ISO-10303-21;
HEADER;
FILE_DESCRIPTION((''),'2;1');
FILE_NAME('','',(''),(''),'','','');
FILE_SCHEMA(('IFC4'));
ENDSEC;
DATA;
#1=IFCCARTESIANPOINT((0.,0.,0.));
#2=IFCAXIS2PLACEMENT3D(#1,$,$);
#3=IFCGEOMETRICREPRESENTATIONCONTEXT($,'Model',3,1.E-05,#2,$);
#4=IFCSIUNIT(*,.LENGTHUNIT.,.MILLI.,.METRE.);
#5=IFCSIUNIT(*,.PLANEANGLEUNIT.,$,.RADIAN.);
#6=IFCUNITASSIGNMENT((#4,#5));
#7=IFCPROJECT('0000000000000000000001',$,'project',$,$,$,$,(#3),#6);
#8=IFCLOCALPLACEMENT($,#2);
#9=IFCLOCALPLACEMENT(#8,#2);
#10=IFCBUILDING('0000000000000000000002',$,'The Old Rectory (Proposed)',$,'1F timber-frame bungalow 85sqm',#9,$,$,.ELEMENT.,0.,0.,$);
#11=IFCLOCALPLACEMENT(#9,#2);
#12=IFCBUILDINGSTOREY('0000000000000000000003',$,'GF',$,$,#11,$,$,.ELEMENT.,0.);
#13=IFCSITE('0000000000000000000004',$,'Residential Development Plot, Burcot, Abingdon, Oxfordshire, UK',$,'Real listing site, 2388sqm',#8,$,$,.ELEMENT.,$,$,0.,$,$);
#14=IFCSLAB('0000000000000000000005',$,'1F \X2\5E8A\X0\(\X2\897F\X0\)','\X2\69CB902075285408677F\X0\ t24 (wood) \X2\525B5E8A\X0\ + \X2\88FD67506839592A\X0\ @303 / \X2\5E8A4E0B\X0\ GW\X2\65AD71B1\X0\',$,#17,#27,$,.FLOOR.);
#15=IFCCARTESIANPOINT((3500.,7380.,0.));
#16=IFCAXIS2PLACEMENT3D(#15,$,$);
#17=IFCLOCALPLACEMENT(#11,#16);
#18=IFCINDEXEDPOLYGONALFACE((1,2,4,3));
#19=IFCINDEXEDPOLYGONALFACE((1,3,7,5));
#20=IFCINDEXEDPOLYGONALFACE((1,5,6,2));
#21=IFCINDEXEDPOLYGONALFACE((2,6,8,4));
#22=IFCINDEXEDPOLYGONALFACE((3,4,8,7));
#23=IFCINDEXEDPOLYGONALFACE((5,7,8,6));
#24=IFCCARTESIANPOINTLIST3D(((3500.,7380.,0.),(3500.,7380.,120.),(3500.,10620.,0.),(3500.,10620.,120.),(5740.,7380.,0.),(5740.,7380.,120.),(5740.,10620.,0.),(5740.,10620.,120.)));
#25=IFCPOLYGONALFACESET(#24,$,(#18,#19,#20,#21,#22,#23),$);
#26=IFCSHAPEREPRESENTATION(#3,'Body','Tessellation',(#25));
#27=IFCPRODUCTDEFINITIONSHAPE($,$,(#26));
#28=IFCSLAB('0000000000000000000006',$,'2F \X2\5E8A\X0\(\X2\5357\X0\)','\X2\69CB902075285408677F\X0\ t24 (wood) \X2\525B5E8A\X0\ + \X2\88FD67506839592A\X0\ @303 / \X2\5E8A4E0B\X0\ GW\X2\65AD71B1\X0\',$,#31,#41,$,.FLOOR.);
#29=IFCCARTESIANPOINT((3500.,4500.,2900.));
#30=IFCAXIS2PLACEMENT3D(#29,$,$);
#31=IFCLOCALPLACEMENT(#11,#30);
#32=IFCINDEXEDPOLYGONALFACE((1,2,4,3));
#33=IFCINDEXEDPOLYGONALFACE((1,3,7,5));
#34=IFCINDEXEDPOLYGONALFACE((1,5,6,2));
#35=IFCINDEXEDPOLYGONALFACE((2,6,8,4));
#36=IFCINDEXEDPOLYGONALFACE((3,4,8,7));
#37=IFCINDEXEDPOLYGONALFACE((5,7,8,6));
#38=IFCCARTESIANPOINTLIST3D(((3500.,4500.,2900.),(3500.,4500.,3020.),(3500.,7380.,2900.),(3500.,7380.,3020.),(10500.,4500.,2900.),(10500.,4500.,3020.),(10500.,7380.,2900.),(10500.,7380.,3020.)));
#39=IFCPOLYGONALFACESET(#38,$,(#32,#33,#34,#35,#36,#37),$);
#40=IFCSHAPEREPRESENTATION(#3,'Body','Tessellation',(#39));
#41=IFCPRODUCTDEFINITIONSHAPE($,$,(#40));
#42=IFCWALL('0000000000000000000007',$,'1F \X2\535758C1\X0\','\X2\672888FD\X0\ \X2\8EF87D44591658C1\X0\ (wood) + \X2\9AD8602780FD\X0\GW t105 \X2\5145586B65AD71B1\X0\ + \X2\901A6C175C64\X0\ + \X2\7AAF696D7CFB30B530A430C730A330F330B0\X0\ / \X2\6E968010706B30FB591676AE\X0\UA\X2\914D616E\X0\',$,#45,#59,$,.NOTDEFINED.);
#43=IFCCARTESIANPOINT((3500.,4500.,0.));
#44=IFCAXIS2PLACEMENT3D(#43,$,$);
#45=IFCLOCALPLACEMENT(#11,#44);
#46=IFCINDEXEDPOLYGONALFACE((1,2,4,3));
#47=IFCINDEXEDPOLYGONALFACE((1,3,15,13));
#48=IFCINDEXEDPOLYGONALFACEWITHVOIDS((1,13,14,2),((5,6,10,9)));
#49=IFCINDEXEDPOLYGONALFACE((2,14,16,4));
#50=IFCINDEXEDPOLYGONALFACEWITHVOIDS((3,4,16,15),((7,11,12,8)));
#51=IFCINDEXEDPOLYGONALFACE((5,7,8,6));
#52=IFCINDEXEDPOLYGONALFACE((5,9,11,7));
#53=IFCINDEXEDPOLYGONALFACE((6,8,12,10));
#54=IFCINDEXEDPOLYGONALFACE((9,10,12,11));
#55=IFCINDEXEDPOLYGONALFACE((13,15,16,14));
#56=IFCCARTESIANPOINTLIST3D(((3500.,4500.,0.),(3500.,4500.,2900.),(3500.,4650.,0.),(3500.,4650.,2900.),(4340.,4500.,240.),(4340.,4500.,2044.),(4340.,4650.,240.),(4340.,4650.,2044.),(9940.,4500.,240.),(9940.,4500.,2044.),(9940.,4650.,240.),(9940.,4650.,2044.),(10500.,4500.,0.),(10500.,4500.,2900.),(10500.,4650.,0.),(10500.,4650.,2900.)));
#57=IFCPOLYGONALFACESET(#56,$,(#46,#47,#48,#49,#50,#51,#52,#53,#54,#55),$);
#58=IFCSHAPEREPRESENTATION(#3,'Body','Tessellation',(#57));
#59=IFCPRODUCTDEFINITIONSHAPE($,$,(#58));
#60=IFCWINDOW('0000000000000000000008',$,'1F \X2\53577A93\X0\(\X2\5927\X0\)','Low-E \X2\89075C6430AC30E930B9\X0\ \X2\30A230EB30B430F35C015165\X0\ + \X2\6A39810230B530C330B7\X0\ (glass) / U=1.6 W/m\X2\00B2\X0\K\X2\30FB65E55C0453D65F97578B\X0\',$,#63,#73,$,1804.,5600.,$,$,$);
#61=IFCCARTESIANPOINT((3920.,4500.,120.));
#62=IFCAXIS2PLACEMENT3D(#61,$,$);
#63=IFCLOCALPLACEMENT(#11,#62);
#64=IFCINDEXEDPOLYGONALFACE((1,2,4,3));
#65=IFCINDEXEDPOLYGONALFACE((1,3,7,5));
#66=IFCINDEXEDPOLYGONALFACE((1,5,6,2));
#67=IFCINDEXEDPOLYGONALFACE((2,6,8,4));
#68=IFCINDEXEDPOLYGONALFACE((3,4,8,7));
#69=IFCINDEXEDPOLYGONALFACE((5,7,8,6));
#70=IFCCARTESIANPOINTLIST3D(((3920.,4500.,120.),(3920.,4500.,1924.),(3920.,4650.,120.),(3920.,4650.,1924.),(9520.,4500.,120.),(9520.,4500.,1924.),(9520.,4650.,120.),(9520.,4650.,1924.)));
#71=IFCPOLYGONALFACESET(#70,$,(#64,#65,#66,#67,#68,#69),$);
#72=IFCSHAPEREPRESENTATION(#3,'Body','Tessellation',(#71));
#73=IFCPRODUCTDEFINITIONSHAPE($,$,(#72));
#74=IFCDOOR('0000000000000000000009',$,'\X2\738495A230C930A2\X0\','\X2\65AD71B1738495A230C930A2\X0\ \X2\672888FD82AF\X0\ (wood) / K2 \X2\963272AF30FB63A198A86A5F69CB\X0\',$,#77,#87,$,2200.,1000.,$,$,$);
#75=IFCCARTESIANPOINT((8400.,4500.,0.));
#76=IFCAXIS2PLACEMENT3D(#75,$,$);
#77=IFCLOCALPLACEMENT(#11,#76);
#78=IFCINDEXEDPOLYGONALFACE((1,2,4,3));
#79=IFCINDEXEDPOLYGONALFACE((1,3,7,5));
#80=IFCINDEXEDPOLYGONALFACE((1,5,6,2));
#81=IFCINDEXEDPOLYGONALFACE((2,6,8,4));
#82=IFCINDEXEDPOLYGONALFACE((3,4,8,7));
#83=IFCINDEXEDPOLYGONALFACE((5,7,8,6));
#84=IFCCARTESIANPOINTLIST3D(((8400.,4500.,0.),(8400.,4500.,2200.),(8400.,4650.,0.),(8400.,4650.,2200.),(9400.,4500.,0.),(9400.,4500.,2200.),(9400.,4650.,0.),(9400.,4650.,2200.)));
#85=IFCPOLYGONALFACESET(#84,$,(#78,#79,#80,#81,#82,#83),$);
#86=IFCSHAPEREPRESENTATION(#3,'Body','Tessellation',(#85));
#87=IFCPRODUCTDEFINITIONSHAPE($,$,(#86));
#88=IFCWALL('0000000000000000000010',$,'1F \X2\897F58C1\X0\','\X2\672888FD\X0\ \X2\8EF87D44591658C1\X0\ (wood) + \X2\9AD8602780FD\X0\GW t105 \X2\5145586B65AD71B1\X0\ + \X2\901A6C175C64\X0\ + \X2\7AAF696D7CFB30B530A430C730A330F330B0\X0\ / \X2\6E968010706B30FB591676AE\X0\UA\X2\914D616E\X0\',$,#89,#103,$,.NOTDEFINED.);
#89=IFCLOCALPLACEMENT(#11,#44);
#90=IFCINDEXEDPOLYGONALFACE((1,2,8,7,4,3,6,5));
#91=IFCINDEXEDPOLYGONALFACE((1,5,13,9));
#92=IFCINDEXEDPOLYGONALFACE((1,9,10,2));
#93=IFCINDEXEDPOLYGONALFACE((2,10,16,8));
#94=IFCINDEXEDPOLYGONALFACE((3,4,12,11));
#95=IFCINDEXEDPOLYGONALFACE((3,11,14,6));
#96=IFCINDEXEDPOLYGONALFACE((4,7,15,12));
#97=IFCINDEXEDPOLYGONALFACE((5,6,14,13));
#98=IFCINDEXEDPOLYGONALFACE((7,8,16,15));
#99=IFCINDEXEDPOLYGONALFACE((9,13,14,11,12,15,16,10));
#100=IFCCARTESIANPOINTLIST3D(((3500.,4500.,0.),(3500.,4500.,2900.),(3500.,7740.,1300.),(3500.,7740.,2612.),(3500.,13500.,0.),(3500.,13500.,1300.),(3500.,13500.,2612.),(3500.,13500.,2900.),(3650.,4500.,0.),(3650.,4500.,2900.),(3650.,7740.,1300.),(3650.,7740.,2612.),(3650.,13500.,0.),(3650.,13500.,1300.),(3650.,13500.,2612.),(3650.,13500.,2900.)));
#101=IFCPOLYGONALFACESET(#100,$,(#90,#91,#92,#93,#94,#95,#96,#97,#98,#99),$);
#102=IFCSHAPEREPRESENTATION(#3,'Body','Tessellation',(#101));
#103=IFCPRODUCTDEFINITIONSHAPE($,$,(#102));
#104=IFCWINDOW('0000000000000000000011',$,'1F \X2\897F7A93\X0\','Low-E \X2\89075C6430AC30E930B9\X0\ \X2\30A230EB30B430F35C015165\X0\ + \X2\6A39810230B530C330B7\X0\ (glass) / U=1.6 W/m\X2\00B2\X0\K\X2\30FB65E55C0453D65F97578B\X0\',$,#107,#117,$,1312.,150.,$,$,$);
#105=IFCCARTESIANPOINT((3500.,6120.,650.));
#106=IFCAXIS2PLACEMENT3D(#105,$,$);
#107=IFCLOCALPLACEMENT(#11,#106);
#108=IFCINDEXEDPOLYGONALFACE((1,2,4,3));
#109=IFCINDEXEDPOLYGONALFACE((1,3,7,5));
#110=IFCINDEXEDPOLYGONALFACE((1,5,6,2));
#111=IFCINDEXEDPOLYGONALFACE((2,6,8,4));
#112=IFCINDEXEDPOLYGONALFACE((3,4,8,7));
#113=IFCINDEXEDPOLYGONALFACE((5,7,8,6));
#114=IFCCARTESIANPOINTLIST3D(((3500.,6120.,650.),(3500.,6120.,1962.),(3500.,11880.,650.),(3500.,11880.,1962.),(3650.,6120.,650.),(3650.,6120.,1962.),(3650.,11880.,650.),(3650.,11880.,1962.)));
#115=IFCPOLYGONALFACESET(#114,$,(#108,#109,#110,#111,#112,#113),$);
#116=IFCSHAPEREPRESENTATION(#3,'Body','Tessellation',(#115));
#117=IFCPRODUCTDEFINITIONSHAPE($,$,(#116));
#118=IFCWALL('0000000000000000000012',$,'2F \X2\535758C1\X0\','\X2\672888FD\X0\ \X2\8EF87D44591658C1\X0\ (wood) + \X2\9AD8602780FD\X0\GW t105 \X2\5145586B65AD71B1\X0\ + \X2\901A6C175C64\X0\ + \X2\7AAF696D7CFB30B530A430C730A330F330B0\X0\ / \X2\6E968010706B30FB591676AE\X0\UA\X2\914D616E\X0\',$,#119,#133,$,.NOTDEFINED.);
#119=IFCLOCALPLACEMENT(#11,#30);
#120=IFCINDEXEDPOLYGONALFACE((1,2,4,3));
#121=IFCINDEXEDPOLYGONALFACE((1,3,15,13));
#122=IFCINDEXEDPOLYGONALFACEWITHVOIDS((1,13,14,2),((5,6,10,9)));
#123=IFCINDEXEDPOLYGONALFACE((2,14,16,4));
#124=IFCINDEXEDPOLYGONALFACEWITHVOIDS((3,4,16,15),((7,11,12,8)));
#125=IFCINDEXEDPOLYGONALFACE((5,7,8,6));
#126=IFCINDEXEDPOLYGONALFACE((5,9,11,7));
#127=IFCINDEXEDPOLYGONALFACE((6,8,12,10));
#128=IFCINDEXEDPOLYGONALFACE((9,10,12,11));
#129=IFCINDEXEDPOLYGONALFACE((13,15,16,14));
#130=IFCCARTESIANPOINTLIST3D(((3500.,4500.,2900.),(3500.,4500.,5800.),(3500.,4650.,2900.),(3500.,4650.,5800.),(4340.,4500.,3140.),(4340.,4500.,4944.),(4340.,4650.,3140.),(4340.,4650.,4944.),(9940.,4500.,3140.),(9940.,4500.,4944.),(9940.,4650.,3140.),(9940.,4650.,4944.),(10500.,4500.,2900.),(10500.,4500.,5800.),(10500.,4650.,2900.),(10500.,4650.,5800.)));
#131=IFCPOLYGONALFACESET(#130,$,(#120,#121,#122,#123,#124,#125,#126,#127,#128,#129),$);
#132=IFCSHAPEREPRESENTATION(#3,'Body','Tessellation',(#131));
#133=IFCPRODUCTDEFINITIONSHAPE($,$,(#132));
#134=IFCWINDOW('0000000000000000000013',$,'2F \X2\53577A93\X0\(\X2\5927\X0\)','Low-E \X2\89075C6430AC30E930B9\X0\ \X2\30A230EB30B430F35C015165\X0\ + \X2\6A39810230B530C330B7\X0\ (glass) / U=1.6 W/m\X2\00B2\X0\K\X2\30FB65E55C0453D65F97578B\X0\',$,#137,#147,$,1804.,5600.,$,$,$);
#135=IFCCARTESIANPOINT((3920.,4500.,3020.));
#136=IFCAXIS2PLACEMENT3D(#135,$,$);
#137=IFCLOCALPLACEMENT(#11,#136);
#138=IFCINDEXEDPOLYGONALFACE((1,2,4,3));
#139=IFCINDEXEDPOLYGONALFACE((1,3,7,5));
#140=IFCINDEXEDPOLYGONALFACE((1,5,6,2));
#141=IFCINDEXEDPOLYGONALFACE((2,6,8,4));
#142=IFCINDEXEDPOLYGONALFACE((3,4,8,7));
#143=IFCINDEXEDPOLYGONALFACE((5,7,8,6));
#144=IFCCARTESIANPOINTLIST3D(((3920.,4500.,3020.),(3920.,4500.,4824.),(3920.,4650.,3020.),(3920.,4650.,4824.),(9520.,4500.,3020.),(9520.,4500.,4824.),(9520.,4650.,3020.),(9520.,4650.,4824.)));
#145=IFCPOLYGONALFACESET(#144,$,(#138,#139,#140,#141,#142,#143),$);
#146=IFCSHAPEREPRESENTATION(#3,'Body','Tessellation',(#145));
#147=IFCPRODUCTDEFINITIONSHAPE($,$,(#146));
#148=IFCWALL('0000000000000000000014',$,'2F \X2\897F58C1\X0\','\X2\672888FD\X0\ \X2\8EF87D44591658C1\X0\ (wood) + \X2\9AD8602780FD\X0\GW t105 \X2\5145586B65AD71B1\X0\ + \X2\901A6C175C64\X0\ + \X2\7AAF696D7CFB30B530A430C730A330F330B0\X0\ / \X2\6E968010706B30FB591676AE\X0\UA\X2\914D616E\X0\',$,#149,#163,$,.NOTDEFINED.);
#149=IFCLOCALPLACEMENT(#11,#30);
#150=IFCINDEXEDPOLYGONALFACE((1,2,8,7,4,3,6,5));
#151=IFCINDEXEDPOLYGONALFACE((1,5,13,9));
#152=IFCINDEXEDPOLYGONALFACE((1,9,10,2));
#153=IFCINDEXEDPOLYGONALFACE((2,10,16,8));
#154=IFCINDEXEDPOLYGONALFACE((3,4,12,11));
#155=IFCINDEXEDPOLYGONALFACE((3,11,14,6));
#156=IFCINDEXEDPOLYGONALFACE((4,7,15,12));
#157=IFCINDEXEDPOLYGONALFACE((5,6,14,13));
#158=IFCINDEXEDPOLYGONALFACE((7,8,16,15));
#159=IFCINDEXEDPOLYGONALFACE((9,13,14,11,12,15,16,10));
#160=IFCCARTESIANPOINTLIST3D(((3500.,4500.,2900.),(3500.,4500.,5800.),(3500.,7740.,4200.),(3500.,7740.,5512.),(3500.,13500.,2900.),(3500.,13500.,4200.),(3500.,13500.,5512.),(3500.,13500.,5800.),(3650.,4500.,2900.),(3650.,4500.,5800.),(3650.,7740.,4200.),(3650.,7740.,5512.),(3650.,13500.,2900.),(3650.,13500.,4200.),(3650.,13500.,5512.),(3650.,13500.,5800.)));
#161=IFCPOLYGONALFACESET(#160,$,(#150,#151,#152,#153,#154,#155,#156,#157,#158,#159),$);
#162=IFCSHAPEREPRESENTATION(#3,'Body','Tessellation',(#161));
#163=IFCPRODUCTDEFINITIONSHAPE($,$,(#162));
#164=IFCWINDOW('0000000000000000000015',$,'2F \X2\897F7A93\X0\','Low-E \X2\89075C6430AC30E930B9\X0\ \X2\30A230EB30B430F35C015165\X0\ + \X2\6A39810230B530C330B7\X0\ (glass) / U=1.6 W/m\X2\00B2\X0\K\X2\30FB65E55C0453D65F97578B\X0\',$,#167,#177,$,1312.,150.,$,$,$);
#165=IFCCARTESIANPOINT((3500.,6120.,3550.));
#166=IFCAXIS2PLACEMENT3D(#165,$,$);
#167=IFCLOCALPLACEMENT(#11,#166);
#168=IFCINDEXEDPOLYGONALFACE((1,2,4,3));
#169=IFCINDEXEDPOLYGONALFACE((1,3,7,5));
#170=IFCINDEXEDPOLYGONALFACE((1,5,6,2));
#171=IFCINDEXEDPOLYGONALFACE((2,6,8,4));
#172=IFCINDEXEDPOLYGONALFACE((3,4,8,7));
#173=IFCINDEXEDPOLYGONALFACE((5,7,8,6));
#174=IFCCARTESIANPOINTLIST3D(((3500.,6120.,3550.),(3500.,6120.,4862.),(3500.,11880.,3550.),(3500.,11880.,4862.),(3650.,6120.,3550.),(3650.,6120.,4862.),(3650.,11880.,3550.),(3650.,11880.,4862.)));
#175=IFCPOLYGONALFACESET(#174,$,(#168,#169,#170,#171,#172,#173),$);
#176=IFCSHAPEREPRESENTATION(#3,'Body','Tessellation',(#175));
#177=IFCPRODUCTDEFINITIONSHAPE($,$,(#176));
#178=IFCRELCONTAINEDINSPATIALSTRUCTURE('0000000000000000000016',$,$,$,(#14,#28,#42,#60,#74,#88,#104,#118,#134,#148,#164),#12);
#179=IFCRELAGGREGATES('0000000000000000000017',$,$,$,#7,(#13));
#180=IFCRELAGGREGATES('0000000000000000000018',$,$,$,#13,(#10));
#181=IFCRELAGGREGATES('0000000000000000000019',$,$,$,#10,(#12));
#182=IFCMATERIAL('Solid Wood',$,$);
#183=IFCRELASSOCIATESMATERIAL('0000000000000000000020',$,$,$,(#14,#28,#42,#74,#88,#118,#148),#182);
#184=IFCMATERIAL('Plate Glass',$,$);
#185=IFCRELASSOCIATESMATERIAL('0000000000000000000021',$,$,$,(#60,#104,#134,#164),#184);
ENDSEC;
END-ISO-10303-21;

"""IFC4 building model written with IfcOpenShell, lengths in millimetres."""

from ifc_helpers import new_model, si_unit, frame, frame_2d, origin, place, context, project, spatial, rectangle, extrude, material, element, fill, save


model = new_model("IFC4")

# Units and contexts
model_context = context("Model", 3, precision=1e-05, world=origin())
ifc_project = project(units=[si_unit("LENGTHUNIT", "METRE", prefix="MILLI"), si_unit("PLANEANGLEUNIT", "RADIAN")], contexts=[model_context])

# Site, building, storey
site_placement = place(None, origin())
site = spatial("IfcSite", under=ifc_project, at=site_placement, Name="Residential Development Plot, Burcot, Abingdon, Oxfordshire, UK", ObjectType="Real listing site, 2388sqm", CompositionType="ELEMENT", RefElevation=0.0)
building_placement = place(site_placement, origin())
building = spatial("IfcBuilding", under=site, at=building_placement, Name="The Old Rectory (Proposed)", ObjectType="1F timber-frame bungalow 85sqm", CompositionType="ELEMENT", ElevationOfRefHeight=0.0, ElevationOfTerrain=0.0)
storey_placement = place(building_placement, origin())
storey = spatial("IfcBuildingStorey", under=building, at=storey_placement, Name="GF", CompositionType="ELEMENT", Elevation=0.0)

# Slabs
ifc_material_1 = material(Name="Solid Wood")
slab_1_placement = place(storey_placement, frame((3500.0, 7380.0, 0.0)))
element("IfcSlab", 1, at=slab_1_placement, inside=storey, material=ifc_material_1, Name="1F 床(西)", Description="構造用合板 t24 (wood) 剛床 + 製材根太 @303 / 床下 GW断熱", PredefinedType="FLOOR", context=model_context, shape_type="SweptSolid", body=[
    extrude(rectangle(XDim=2240.0, YDim=3240.0, at=frame_2d((1120.0, 1620.0))), frame((3500.0, 7380.0, 0.0)), (0.0, 0.0, 1.0), 120.0),
])
slab_2_placement = place(storey_placement, frame((3500.0, 4500.0, 2900.0)))
element("IfcSlab", 2, at=slab_2_placement, inside=storey, material=ifc_material_1, Name="2F 床(南)", Description="構造用合板 t24 (wood) 剛床 + 製材根太 @303 / 床下 GW断熱", PredefinedType="FLOOR", context=model_context, shape_type="SweptSolid", body=[
    extrude(rectangle(XDim=7000.0, YDim=2880.0, at=frame_2d((3500.0, 1440.0))), frame((3500.0, 4500.0, 2900.0)), (0.0, 0.0, 1.0), 120.0),
])

# Wall, openings, window, door
wall_1_placement = place(storey_placement, frame((3500.0, 4500.0, 0.0)))
wall_1 = element("IfcWall", 3, at=wall_1_placement, inside=storey, material=ifc_material_1, Name="1F 南壁", Description="木製 軸組外壁 (wood) + 高性能GW t105 充填断熱 + 通気層 + 窯業系サイディング / 準耐火・外皮UA配慮", PredefinedType="NOTDEFINED", context=model_context, shape_type="SweptSolid", body=[
    extrude(rectangle(XDim=7000.0, YDim=150.0, at=frame_2d((3500.0, 75.0))), frame((3500.0, 4500.0, 0.0)), (0.0, 0.0, 1.0), 2900.0),
])
opening_1_placement = place(storey_placement, frame((3920.0, 4500.0, 120.0)))
opening_1 = element("IfcOpeningElement", 4, at=opening_1_placement, cuts=wall_1, PredefinedType="NOTDEFINED", context=model_context, shape_type="SweptSolid", body=[
    extrude(rectangle(XDim=5600.0, YDim=150.0, at=frame_2d((2800.0, 75.0))), frame((3920.0, 4500.0, 120.0)), (0.0, 0.0, 1.0), 1804.0),
])
opening_2_placement = place(storey_placement, frame((8400.0, 4500.0, 0.0)))
opening_2 = element("IfcOpeningElement", 5, at=opening_2_placement, cuts=wall_1, PredefinedType="NOTDEFINED", context=model_context, shape_type="SweptSolid", body=[
    extrude(rectangle(XDim=1000.0, YDim=150.0, at=frame_2d((500.0, 75.0))), frame((8400.0, 4500.0, 0.0)), (0.0, 0.0, 1.0), 2200.0),
])
ifc_material_2 = material(Name="Plate Glass")
window_1_placement = place(storey_placement, frame((3920.0, 4500.0, 120.0)))
window_1 = element("IfcWindow", 6, at=window_1_placement, inside=storey, material=ifc_material_2, Name="1F 南窓(大)", Description="Low-E 複層ガラス アルゴン封入 + 樹脂サッシ (glass) / U=1.6 W/m²K・日射取得型", OverallHeight=1804.0, OverallWidth=5600.0, context=model_context, shape_type="SweptSolid", body=[
    extrude(rectangle(XDim=5600.0, YDim=150.0, at=frame_2d((2800.0, 75.0))), frame((3920.0, 4500.0, 120.0)), (0.0, 0.0, 1.0), 1804.0),
])
fill(opening_1, window_1)
door_placement = place(storey_placement, frame((8400.0, 4500.0, 0.0)))
door = element("IfcDoor", 7, at=door_placement, inside=storey, material=ifc_material_1, Name="玄関ドア", Description="断熱玄関ドア 木製芯 (wood) / K2 防犯・採風機構", OverallHeight=2200.0, OverallWidth=1000.0, context=model_context, shape_type="SweptSolid", body=[
    extrude(rectangle(XDim=1000.0, YDim=150.0, at=frame_2d((500.0, 75.0))), frame((8400.0, 4500.0, 0.0)), (0.0, 0.0, 1.0), 2200.0),
])
fill(opening_2, door)

# Walls, openings, windows
wall_2_placement = place(storey_placement, frame((3500.0, 4500.0, 0.0)))
wall_2 = element("IfcWall", 8, at=wall_2_placement, inside=storey, material=ifc_material_1, Name="1F 西壁", Description="木製 軸組外壁 (wood) + 高性能GW t105 充填断熱 + 通気層 + 窯業系サイディング / 準耐火・外皮UA配慮", PredefinedType="NOTDEFINED", context=model_context, shape_type="SweptSolid", body=[
    extrude(rectangle(XDim=150.0, YDim=9000.0, at=frame_2d((75.0, 4500.0))), frame((3500.0, 4500.0, 0.0)), (0.0, 0.0, 1.0), 2900.0),
])
opening_3_placement = place(storey_placement, frame((3500.0, 6120.0, 650.0)))
opening_3 = element("IfcOpeningElement", 9, at=opening_3_placement, cuts=wall_2, PredefinedType="NOTDEFINED", context=model_context, shape_type="SweptSolid", body=[
    extrude(rectangle(XDim=150.0, YDim=5760.0, at=frame_2d((75.0, 2880.0))), frame((3500.0, 6120.0, 650.0)), (0.0, 0.0, 1.0), 1312.0),
])
window_2_placement = place(storey_placement, frame((3500.0, 6120.0, 650.0)))
window_2 = element("IfcWindow", 10, at=window_2_placement, inside=storey, material=ifc_material_2, Name="1F 西窓", Description="Low-E 複層ガラス アルゴン封入 + 樹脂サッシ (glass) / U=1.6 W/m²K・日射取得型", OverallHeight=1312.0, OverallWidth=150.0, context=model_context, shape_type="SweptSolid", body=[
    extrude(rectangle(XDim=150.0, YDim=5760.0, at=frame_2d((75.0, 2880.0))), frame((3500.0, 6120.0, 650.0)), (0.0, 0.0, 1.0), 1312.0),
])
fill(opening_3, window_2)
wall_3_placement = place(storey_placement, frame((3500.0, 4500.0, 2900.0)))
wall_3 = element("IfcWall", 11, at=wall_3_placement, inside=storey, material=ifc_material_1, Name="2F 南壁", Description="木製 軸組外壁 (wood) + 高性能GW t105 充填断熱 + 通気層 + 窯業系サイディング / 準耐火・外皮UA配慮", PredefinedType="NOTDEFINED", context=model_context, shape_type="SweptSolid", body=[
    extrude(rectangle(XDim=7000.0, YDim=150.0, at=frame_2d((3500.0, 75.0))), frame((3500.0, 4500.0, 2900.0)), (0.0, 0.0, 1.0), 2900.0),
])
opening_4_placement = place(storey_placement, frame((3920.0, 4500.0, 3020.0)))
opening_4 = element("IfcOpeningElement", 12, at=opening_4_placement, cuts=wall_3, PredefinedType="NOTDEFINED", context=model_context, shape_type="SweptSolid", body=[
    extrude(rectangle(XDim=5600.0, YDim=150.0, at=frame_2d((2800.0, 75.0))), frame((3920.0, 4500.0, 3020.0)), (0.0, 0.0, 1.0), 1804.0),
])
window_3_placement = place(storey_placement, frame((3920.0, 4500.0, 3020.0)))
window_3 = element("IfcWindow", 13, at=window_3_placement, inside=storey, material=ifc_material_2, Name="2F 南窓(大)", Description="Low-E 複層ガラス アルゴン封入 + 樹脂サッシ (glass) / U=1.6 W/m²K・日射取得型", OverallHeight=1804.0, OverallWidth=5600.0, context=model_context, shape_type="SweptSolid", body=[
    extrude(rectangle(XDim=5600.0, YDim=150.0, at=frame_2d((2800.0, 75.0))), frame((3920.0, 4500.0, 3020.0)), (0.0, 0.0, 1.0), 1804.0),
])
fill(opening_4, window_3)
wall_4_placement = place(storey_placement, frame((3500.0, 4500.0, 2900.0)))
wall_4 = element("IfcWall", 14, at=wall_4_placement, inside=storey, material=ifc_material_1, Name="2F 西壁", Description="木製 軸組外壁 (wood) + 高性能GW t105 充填断熱 + 通気層 + 窯業系サイディング / 準耐火・外皮UA配慮", PredefinedType="NOTDEFINED", context=model_context, shape_type="SweptSolid", body=[
    extrude(rectangle(XDim=150.0, YDim=9000.0, at=frame_2d((75.0, 4500.0))), frame((3500.0, 4500.0, 2900.0)), (0.0, 0.0, 1.0), 2900.0),
])
opening_5_placement = place(storey_placement, frame((3500.0, 6120.0, 3550.0)))
opening_5 = element("IfcOpeningElement", 15, at=opening_5_placement, cuts=wall_4, PredefinedType="NOTDEFINED", context=model_context, shape_type="SweptSolid", body=[
    extrude(rectangle(XDim=150.0, YDim=5760.0, at=frame_2d((75.0, 2880.0))), frame((3500.0, 6120.0, 3550.0)), (0.0, 0.0, 1.0), 1312.0),
])
window_4_placement = place(storey_placement, frame((3500.0, 6120.0, 3550.0)))
window_4 = element("IfcWindow", 16, at=window_4_placement, inside=storey, material=ifc_material_2, Name="2F 西窓", Description="Low-E 複層ガラス アルゴン封入 + 樹脂サッシ (glass) / U=1.6 W/m²K・日射取得型", OverallHeight=1312.0, OverallWidth=150.0, context=model_context, shape_type="SweptSolid", body=[
    extrude(rectangle(XDim=150.0, YDim=5760.0, at=frame_2d((75.0, 2880.0))), frame((3500.0, 6120.0, 3550.0)), (0.0, 0.0, 1.0), 1312.0),
])
fill(opening_5, window_4)

save(model, "model.ifc")
